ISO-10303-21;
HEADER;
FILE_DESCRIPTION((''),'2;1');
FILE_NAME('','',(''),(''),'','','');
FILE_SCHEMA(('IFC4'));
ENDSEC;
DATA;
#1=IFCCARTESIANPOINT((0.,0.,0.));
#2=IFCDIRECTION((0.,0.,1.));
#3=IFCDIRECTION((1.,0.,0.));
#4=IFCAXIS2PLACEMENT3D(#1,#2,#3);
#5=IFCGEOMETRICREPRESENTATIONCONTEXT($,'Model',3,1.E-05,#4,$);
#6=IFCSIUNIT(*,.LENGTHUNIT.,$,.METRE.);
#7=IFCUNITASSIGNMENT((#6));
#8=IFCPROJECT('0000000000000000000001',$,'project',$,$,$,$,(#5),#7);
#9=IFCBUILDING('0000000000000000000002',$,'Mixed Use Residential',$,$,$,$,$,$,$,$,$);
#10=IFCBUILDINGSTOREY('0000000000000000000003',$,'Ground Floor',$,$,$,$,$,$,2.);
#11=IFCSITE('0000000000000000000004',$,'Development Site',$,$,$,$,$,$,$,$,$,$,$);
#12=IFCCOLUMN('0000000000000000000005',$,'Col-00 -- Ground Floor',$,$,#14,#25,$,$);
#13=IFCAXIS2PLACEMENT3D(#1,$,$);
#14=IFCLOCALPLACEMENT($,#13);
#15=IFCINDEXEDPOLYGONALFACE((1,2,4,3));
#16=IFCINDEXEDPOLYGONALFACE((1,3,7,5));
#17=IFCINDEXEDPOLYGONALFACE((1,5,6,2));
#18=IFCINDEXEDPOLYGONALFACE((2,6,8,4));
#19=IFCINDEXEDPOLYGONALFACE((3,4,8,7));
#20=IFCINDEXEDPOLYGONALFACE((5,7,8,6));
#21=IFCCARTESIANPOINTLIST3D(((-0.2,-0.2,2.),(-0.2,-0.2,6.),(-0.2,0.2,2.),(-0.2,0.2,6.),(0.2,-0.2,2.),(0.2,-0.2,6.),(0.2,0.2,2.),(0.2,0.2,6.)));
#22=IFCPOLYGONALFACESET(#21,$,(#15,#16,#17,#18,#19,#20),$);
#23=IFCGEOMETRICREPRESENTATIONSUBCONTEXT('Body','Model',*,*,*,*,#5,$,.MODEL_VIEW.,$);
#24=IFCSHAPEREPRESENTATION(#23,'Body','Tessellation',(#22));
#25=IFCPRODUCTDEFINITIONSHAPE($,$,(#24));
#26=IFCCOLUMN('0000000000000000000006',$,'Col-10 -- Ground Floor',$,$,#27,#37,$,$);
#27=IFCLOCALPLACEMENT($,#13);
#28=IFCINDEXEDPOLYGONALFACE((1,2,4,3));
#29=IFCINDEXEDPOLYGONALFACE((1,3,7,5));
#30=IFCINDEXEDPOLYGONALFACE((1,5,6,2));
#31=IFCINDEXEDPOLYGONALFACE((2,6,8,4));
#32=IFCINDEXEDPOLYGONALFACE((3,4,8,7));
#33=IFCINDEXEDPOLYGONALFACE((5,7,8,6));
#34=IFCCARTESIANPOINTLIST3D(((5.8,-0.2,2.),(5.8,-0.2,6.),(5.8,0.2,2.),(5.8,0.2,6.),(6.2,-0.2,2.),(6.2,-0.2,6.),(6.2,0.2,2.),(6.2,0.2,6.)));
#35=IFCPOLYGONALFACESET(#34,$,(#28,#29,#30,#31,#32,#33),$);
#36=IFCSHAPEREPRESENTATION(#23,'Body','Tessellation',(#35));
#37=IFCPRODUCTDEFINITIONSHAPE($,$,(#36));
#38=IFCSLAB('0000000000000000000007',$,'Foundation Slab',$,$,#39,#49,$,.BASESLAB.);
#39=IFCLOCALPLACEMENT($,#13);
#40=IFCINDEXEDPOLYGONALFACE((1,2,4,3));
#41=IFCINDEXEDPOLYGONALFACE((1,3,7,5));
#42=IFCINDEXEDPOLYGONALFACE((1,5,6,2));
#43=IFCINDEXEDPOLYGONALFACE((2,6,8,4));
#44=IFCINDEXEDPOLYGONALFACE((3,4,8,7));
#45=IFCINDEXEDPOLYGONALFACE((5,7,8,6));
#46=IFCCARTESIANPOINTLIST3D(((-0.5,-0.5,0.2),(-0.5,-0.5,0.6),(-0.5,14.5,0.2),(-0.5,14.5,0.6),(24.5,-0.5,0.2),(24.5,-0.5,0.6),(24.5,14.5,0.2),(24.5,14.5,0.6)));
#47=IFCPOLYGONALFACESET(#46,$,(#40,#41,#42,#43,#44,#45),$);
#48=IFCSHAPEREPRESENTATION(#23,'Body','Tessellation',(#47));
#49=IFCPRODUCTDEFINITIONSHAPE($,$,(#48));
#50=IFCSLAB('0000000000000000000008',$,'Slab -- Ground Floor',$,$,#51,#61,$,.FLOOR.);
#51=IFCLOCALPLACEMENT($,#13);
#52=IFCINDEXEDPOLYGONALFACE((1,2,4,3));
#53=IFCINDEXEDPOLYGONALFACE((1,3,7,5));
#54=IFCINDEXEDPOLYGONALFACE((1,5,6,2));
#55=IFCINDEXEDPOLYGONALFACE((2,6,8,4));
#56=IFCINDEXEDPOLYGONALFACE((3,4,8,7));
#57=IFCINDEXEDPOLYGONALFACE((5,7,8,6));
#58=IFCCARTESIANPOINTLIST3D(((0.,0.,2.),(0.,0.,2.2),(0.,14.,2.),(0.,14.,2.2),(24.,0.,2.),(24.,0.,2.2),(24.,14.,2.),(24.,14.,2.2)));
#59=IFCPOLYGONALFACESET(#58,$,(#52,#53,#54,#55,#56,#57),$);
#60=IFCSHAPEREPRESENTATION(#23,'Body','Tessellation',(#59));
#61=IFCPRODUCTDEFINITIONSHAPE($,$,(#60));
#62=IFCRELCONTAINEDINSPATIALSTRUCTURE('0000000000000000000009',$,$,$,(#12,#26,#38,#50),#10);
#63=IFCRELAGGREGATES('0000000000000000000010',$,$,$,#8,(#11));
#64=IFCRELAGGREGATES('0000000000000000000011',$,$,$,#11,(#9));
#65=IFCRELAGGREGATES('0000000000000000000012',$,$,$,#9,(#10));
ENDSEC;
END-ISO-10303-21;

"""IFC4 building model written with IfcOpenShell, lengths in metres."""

from ifc_helpers import new_model, si_unit, frame, origin_with_axes, place, context, subcontext, project, spatial, indexed_curve, rectangle, outline, extrude, element, save


model = new_model("IFC4")

# Units and contexts
model_context = context("Model", 3, precision=1e-05, world=origin_with_axes())
body_context = subcontext(model_context, "Body", "Model", "MODEL_VIEW")
ifc_project = project(units=[si_unit("LENGTHUNIT", "METRE")], contexts=[model_context])

# Site, building, storey
site = spatial("IfcSite", under=ifc_project, Name="Development Site")
building = spatial("IfcBuilding", under=site, Name="Mixed Use Residential")
storey = spatial("IfcBuildingStorey", under=building, Name="Ground Floor", Elevation=2.0)

# Columns
for number, where, z_axis, x_axis, name in (
    (1, (0.0, 0.0, 2.0), (0.0, 0.0, 1.0), (1.0, 0.0, 0.0), "Col-00 -- Ground Floor"),
    (2, (6.0, 0.0, 2.0), (0.0, 0.0, 1.0), (1.0, 0.0, 0.0), "Col-10 -- Ground Floor"),
):
    element("IfcColumn", number, at=place(None, frame(where, z_axis=z_axis, x_axis=x_axis)), inside=storey, Name=name, context=body_context, shape_type="SweptSolid", body=[
        extrude(rectangle(XDim=0.4, YDim=0.4), origin_with_axes(), (0.0, 0.0, 1.0), 4.0),
    ])

# Slabs
slab_1_placement = place(None, frame((0.0, 0.0, 0.2), z_axis=(0.0, 0.0, 1.0), x_axis=(1.0, 0.0, 0.0)))
element("IfcSlab", 3, at=slab_1_placement, inside=storey, Name="Foundation Slab", PredefinedType="BASESLAB", context=body_context, shape_type="SweptSolid", body=[
    extrude(outline(indexed_curve([(-0.5, -0.5), (24.5, -0.5), (24.5, 14.5), (-0.5, 14.5), (-0.5, -0.5)])), None, (0.0, 0.0, 1.0), 0.4),
])
slab_2_placement = place(None, frame((0.0, 0.0, 2.0), z_axis=(0.0, 0.0, 1.0), x_axis=(1.0, 0.0, 0.0)))
element("IfcSlab", 4, at=slab_2_placement, inside=storey, Name="Slab -- Ground Floor", PredefinedType="FLOOR", context=body_context, shape_type="SweptSolid", body=[
    extrude(outline(indexed_curve([(0.0, 0.0), (24.0, 0.0), (24.0, 14.0), (0.0, 14.0), (0.0, 0.0)])), None, (0.0, 0.0, 1.0), 0.2),
])

save(model, "model.ifc")
